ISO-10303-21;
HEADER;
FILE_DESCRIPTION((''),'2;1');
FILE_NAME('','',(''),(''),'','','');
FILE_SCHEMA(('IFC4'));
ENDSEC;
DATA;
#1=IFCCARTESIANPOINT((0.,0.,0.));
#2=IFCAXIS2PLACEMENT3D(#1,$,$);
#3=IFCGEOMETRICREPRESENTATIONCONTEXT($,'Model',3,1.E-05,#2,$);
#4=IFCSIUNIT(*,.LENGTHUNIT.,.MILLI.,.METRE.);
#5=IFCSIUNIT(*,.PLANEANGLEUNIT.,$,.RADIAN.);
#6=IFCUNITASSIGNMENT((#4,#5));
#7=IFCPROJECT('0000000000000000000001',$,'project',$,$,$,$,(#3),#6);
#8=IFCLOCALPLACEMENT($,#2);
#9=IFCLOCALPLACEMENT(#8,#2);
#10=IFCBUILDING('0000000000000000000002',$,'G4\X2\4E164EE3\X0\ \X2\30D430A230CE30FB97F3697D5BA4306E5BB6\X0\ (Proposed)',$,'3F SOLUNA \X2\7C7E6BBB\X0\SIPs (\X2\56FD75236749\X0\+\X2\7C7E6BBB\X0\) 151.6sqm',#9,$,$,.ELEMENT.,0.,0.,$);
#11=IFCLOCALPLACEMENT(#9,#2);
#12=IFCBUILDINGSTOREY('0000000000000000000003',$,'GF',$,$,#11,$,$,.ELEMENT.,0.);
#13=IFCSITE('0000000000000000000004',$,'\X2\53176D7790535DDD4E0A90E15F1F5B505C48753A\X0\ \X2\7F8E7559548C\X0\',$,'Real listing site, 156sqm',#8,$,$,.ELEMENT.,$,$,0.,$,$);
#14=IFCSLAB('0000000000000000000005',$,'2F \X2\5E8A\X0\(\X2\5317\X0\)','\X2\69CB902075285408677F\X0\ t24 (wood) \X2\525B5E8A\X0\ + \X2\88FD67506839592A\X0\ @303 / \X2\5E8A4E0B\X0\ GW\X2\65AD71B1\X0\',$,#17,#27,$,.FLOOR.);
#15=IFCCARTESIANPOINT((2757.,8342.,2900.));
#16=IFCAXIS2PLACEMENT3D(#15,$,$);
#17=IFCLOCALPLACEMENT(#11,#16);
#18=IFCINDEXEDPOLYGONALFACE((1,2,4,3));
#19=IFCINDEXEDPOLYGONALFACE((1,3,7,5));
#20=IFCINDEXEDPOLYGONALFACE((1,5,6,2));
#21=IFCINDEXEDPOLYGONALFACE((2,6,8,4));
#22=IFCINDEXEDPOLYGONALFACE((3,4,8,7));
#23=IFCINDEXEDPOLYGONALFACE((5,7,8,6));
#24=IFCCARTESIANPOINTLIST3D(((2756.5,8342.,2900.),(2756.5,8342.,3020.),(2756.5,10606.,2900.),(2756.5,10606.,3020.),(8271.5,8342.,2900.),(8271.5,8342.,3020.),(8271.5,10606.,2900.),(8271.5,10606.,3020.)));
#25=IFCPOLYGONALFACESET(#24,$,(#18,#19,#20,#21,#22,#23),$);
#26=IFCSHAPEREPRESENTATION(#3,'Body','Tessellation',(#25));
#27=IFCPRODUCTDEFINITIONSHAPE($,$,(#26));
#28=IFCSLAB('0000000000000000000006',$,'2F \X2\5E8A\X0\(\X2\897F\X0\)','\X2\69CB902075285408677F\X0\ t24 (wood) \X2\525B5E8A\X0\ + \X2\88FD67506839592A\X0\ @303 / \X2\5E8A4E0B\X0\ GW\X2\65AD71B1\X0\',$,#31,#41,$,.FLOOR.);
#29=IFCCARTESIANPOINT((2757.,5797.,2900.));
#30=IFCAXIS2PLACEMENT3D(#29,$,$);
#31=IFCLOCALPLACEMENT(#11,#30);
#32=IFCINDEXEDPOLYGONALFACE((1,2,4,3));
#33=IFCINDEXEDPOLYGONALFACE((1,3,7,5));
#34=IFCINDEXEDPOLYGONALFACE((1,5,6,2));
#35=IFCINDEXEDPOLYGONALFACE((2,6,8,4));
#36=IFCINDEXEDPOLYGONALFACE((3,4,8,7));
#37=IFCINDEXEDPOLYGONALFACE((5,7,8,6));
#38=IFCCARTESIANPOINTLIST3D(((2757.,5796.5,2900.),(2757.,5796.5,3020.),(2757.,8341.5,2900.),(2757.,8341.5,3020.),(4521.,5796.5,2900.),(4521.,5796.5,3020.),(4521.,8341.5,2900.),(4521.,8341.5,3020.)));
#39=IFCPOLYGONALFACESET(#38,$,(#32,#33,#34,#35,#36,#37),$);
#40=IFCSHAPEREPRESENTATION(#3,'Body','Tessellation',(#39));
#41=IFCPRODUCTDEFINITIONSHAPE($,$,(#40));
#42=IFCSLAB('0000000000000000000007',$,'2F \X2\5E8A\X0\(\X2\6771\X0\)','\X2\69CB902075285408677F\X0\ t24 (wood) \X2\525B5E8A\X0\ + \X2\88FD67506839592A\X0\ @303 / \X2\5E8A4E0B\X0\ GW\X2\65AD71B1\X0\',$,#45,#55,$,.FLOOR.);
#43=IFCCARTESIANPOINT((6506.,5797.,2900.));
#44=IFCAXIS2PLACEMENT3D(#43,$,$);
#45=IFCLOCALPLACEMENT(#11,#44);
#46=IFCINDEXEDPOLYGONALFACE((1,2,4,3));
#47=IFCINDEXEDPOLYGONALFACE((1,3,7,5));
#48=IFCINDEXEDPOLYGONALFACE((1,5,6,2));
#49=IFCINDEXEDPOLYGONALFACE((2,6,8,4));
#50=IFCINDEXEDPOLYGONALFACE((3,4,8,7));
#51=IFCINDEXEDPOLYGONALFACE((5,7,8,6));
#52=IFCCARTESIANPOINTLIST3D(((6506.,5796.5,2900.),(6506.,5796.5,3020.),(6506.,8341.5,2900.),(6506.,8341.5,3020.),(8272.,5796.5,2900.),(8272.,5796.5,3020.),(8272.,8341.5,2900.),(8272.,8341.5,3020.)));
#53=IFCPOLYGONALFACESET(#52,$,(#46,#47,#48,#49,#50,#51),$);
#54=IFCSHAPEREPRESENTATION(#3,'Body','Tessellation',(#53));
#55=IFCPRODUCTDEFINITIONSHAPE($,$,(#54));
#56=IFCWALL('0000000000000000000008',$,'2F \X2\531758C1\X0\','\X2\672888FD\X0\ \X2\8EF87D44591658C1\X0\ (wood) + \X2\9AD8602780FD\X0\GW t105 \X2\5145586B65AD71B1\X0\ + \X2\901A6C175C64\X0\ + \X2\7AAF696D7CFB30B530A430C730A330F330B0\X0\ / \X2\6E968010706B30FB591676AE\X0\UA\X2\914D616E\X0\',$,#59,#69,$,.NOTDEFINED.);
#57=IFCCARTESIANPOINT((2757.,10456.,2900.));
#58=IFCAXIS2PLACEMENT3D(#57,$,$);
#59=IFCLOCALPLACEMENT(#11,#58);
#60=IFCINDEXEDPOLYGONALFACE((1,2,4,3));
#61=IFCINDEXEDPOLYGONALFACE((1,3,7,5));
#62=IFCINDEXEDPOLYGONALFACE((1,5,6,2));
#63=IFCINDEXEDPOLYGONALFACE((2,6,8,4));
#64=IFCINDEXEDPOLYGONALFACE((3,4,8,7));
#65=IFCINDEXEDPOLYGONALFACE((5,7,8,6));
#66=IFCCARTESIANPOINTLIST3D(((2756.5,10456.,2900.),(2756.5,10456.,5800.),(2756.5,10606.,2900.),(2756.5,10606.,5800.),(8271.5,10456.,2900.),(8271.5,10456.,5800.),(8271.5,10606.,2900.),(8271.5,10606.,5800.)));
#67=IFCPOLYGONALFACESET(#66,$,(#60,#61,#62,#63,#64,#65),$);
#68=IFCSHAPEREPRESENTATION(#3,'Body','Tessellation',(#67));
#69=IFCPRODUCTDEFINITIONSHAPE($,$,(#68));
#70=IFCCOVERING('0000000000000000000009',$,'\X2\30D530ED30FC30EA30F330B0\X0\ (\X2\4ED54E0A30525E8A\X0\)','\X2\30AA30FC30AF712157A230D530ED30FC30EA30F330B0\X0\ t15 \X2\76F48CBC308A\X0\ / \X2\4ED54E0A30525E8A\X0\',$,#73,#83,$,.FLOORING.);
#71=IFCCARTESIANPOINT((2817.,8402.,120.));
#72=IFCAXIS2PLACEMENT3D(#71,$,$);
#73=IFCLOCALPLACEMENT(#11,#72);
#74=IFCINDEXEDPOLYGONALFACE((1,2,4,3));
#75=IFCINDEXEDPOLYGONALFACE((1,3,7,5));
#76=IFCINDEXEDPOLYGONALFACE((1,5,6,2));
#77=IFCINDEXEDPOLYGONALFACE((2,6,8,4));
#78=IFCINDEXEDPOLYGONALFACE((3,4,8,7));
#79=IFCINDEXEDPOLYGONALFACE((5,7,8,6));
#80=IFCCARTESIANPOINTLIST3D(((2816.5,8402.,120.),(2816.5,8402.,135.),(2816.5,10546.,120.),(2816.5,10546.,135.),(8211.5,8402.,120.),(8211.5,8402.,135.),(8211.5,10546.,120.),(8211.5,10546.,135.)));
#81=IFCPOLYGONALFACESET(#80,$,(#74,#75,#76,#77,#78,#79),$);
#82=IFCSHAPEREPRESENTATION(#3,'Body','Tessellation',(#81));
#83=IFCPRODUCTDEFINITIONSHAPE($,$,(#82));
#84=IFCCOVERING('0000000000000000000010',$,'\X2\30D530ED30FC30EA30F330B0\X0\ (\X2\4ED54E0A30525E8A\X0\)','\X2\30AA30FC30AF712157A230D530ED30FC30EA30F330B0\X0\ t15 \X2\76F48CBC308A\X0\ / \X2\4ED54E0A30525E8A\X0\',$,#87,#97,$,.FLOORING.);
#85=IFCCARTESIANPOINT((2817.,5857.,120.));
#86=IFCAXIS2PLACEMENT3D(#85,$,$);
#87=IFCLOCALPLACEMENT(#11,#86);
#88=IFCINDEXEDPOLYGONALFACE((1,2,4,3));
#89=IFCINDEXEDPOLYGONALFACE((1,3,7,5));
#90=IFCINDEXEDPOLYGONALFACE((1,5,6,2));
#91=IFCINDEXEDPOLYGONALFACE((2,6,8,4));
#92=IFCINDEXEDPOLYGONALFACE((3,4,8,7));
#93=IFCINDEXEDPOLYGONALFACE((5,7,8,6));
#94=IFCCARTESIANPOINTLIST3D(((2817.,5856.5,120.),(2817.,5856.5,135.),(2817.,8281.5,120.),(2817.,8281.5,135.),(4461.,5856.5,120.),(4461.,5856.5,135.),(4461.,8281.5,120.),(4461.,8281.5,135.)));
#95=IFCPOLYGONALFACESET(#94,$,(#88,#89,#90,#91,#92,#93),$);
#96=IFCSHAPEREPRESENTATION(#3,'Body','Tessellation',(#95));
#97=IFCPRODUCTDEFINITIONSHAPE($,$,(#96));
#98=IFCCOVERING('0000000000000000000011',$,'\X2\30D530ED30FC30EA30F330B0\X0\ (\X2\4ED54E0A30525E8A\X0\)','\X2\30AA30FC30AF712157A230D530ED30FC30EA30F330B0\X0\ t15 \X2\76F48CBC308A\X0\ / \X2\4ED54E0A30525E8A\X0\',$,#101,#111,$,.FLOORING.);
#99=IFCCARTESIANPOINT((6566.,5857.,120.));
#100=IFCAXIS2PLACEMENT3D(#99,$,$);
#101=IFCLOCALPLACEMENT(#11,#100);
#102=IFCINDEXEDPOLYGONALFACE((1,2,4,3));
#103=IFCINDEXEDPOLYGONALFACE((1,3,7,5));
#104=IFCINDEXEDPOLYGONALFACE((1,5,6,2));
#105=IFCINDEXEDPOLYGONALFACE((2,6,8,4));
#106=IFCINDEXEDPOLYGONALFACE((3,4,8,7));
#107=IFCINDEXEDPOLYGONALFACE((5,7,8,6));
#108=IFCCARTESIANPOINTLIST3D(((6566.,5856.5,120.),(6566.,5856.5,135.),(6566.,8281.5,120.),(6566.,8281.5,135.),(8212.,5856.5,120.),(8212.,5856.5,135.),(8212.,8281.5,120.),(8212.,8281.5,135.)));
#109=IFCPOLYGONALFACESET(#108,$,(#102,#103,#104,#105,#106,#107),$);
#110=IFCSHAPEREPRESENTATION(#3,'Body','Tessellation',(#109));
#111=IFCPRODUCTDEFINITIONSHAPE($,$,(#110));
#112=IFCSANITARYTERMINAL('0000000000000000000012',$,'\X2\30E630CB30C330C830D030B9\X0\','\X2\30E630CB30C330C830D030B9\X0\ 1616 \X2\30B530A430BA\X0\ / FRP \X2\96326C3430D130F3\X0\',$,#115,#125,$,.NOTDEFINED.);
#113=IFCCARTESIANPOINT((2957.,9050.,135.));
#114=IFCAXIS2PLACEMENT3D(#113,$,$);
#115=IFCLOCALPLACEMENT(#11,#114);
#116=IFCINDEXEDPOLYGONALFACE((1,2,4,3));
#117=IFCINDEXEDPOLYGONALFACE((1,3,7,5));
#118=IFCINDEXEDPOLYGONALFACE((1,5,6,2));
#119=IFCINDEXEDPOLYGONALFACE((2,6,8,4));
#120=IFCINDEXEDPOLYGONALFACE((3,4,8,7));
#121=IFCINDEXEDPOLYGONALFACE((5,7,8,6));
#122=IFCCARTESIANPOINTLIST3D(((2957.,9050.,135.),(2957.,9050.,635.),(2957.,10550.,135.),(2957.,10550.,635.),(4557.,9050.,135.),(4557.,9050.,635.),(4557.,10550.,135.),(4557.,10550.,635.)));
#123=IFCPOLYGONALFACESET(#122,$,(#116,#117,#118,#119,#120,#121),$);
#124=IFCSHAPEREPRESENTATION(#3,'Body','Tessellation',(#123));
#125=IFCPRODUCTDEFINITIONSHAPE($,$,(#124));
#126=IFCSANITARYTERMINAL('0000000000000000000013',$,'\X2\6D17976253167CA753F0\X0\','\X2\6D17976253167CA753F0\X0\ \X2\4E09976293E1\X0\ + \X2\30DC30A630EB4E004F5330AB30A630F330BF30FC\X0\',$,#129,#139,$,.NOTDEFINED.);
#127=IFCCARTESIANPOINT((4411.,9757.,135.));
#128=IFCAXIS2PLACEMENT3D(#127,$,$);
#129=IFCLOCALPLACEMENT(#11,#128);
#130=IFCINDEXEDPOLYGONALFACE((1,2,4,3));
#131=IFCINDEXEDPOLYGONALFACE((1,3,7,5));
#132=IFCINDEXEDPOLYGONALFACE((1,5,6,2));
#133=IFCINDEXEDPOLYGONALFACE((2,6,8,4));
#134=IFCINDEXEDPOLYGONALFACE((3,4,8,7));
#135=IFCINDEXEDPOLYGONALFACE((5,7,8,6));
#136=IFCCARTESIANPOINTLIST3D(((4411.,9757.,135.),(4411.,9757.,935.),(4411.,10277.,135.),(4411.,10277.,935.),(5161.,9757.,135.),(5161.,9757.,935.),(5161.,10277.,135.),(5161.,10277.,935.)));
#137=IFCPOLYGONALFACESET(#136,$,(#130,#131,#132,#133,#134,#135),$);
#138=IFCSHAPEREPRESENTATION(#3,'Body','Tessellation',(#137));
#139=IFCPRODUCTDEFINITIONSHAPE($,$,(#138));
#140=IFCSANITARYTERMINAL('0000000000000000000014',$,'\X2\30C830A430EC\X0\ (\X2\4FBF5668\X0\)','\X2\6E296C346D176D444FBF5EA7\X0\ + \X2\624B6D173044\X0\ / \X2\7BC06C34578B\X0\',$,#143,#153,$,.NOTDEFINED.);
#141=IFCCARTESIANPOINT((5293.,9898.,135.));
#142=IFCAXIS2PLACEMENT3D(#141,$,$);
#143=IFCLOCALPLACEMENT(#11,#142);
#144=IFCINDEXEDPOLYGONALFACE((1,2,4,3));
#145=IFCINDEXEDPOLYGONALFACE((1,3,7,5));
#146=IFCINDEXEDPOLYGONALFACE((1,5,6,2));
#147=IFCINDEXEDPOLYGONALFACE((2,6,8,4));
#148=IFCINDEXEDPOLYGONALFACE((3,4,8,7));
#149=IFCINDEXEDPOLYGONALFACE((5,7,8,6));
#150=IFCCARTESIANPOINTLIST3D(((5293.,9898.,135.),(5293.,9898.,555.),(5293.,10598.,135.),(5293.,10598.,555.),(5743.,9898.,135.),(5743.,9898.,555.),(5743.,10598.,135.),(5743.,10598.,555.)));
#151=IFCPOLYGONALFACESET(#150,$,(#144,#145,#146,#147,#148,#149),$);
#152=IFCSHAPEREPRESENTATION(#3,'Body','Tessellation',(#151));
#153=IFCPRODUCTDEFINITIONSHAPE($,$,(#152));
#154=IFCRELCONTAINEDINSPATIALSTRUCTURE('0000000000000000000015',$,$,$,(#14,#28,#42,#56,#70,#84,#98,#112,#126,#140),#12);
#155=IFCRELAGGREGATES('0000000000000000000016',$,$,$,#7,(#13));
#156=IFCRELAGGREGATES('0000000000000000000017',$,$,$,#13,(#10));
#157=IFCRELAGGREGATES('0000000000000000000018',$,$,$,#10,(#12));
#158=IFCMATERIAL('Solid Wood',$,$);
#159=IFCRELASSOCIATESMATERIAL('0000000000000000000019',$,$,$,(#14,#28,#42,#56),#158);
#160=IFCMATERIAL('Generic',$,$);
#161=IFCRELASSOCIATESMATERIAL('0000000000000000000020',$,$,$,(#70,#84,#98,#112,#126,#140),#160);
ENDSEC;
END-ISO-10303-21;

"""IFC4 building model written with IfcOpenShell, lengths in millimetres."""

from ifc_helpers import new_model, si_unit, frame, frame_2d, origin, place, context, project, spatial, rectangle, extrude, material, element, save


model = new_model("IFC4")

# Units and contexts
model_context = context("Model", 3, precision=1e-05, world=origin())
ifc_project = project(units=[si_unit("LENGTHUNIT", "METRE", prefix="MILLI"), si_unit("PLANEANGLEUNIT", "RADIAN")], contexts=[model_context])

# Site, building, storey
site_placement = place(None, origin())
site = spatial("IfcSite", under=ifc_project, at=site_placement, Name="北海道川上郡弟子屈町 美留和", ObjectType="Real listing site, 156sqm", CompositionType="ELEMENT", RefElevation=0.0)
building_placement = place(site_placement, origin())
building = spatial("IfcBuilding", under=site, at=building_placement, Name="G4世代 ピアノ・音楽室の家 (Proposed)", ObjectType="3F SOLUNA 籾殻SIPs (国産杉+籾殻) 151.6sqm", CompositionType="ELEMENT", ElevationOfRefHeight=0.0, ElevationOfTerrain=0.0)
storey_placement = place(building_placement, origin())
storey = spatial("IfcBuildingStorey", under=building, at=storey_placement, Name="GF", CompositionType="ELEMENT", Elevation=0.0)

# Slabs
ifc_material_1 = material(Name="Solid Wood")
slab_1_placement = place(storey_placement, frame((2757.0, 8342.0, 2900.0)))
element("IfcSlab", 1, at=slab_1_placement, inside=storey, material=ifc_material_1, Name="2F 床(北)", Description="構造用合板 t24 (wood) 剛床 + 製材根太 @303 / 床下 GW断熱", PredefinedType="FLOOR", context=model_context, shape_type="SweptSolid", body=[
    extrude(rectangle(XDim=5515.0, YDim=2264.0, at=frame_2d((2757.0, 1132.0))), frame((2757.0, 8342.0, 2900.0)), (0.0, 0.0, 1.0), 120.0),
])
slab_2_placement = place(storey_placement, frame((2757.0, 5797.0, 2900.0)))
element("IfcSlab", 2, at=slab_2_placement, inside=storey, material=ifc_material_1, Name="2F 床(西)", Description="構造用合板 t24 (wood) 剛床 + 製材根太 @303 / 床下 GW断熱", PredefinedType="FLOOR", context=model_context, shape_type="SweptSolid", body=[
    extrude(rectangle(XDim=1764.0, YDim=2545.0, at=frame_2d((882.0, 1272.0))), frame((2757.0, 5797.0, 2900.0)), (0.0, 0.0, 1.0), 120.0),
])
slab_3_placement = place(storey_placement, frame((6506.0, 5797.0, 2900.0)))
element("IfcSlab", 3, at=slab_3_placement, inside=storey, material=ifc_material_1, Name="2F 床(東)", Description="構造用合板 t24 (wood) 剛床 + 製材根太 @303 / 床下 GW断熱", PredefinedType="FLOOR", context=model_context, shape_type="SweptSolid", body=[
    extrude(rectangle(XDim=1766.0, YDim=2545.0, at=frame_2d((883.0, 1272.0))), frame((6506.0, 5797.0, 2900.0)), (0.0, 0.0, 1.0), 120.0),
])

# Wall
wall_1_placement = place(storey_placement, frame((2757.0, 10456.0, 2900.0)))
element("IfcWall", 4, at=wall_1_placement, inside=storey, material=ifc_material_1, Name="2F 北壁", Description="木製 軸組外壁 (wood) + 高性能GW t105 充填断熱 + 通気層 + 窯業系サイディング / 準耐火・外皮UA配慮", PredefinedType="NOTDEFINED", context=model_context, shape_type="SweptSolid", body=[
    extrude(rectangle(XDim=5515.0, YDim=150.0, at=frame_2d((2757.0, 75.0))), frame((2757.0, 10456.0, 2900.0)), (0.0, 0.0, 1.0), 2900.0),
])

# Coverings
ifc_material_2 = material(Name="Generic")
covering_1_placement = place(storey_placement, frame((2817.0, 8402.0, 120.0)))
element("IfcCovering", 5, at=covering_1_placement, inside=storey, material=ifc_material_2, Name="フローリング (仕上げ床)", Description="オーク無垢フローリング t15 直貼り / 仕上げ床", PredefinedType="FLOORING", context=model_context, shape_type="SweptSolid", body=[
    extrude(rectangle(XDim=5395.0, YDim=2144.0, at=frame_2d((2697.0, 1072.0))), frame((2817.0, 8402.0, 120.0)), (0.0, 0.0, 1.0), 15.0),
])
covering_2_placement = place(storey_placement, frame((2817.0, 5857.0, 120.0)))
element("IfcCovering", 6, at=covering_2_placement, inside=storey, material=ifc_material_2, Name="フローリング (仕上げ床)", Description="オーク無垢フローリング t15 直貼り / 仕上げ床", PredefinedType="FLOORING", context=model_context, shape_type="SweptSolid", body=[
    extrude(rectangle(XDim=1644.0, YDim=2425.0, at=frame_2d((822.0, 1212.0))), frame((2817.0, 5857.0, 120.0)), (0.0, 0.0, 1.0), 15.0),
])
covering_3_placement = place(storey_placement, frame((6566.0, 5857.0, 120.0)))
element("IfcCovering", 7, at=covering_3_placement, inside=storey, material=ifc_material_2, Name="フローリング (仕上げ床)", Description="オーク無垢フローリング t15 直貼り / 仕上げ床", PredefinedType="FLOORING", context=model_context, shape_type="SweptSolid", body=[
    extrude(rectangle(XDim=1646.0, YDim=2425.0, at=frame_2d((823.0, 1212.0))), frame((6566.0, 5857.0, 120.0)), (0.0, 0.0, 1.0), 15.0),
])

# Sanitary terminals
sanitary_terminal_1_placement = place(storey_placement, frame((2957.0, 9050.0, 135.0)))
element("IfcSanitaryTerminal", 8, at=sanitary_terminal_1_placement, inside=storey, material=ifc_material_2, Name="ユニットバス", Description="ユニットバス 1616 サイズ / FRP 防水パン", PredefinedType="NOTDEFINED", context=model_context, shape_type="SweptSolid", body=[
    extrude(rectangle(XDim=1600.0, YDim=1500.0, at=frame_2d((800.0, 750.0))), frame((2957.0, 9050.0, 135.0)), (0.0, 0.0, 1.0), 500.0),
])
sanitary_terminal_2_placement = place(storey_placement, frame((4411.0, 9757.0, 135.0)))
element("IfcSanitaryTerminal", 9, at=sanitary_terminal_2_placement, inside=storey, material=ifc_material_2, Name="洗面化粧台", Description="洗面化粧台 三面鏡 + ボウル一体カウンター", PredefinedType="NOTDEFINED", context=model_context, shape_type="SweptSolid", body=[
    extrude(rectangle(XDim=750.0, YDim=520.0, at=frame_2d((375.0, 260.0))), frame((4411.0, 9757.0, 135.0)), (0.0, 0.0, 1.0), 800.0),
])
sanitary_terminal_3_placement = place(storey_placement, frame((5293.0, 9898.0, 135.0)))
element("IfcSanitaryTerminal", 10, at=sanitary_terminal_3_placement, inside=storey, material=ifc_material_2, Name="トイレ (便器)", Description="温水洗浄便座 + 手洗い / 節水型", PredefinedType="NOTDEFINED", context=model_context, shape_type="SweptSolid", body=[
    extrude(rectangle(XDim=450.0, YDim=700.0, at=frame_2d((225.0, 350.0))), frame((5293.0, 9898.0, 135.0)), (0.0, 0.0, 1.0), 420.0),
])

save(model, "model.ifc")
